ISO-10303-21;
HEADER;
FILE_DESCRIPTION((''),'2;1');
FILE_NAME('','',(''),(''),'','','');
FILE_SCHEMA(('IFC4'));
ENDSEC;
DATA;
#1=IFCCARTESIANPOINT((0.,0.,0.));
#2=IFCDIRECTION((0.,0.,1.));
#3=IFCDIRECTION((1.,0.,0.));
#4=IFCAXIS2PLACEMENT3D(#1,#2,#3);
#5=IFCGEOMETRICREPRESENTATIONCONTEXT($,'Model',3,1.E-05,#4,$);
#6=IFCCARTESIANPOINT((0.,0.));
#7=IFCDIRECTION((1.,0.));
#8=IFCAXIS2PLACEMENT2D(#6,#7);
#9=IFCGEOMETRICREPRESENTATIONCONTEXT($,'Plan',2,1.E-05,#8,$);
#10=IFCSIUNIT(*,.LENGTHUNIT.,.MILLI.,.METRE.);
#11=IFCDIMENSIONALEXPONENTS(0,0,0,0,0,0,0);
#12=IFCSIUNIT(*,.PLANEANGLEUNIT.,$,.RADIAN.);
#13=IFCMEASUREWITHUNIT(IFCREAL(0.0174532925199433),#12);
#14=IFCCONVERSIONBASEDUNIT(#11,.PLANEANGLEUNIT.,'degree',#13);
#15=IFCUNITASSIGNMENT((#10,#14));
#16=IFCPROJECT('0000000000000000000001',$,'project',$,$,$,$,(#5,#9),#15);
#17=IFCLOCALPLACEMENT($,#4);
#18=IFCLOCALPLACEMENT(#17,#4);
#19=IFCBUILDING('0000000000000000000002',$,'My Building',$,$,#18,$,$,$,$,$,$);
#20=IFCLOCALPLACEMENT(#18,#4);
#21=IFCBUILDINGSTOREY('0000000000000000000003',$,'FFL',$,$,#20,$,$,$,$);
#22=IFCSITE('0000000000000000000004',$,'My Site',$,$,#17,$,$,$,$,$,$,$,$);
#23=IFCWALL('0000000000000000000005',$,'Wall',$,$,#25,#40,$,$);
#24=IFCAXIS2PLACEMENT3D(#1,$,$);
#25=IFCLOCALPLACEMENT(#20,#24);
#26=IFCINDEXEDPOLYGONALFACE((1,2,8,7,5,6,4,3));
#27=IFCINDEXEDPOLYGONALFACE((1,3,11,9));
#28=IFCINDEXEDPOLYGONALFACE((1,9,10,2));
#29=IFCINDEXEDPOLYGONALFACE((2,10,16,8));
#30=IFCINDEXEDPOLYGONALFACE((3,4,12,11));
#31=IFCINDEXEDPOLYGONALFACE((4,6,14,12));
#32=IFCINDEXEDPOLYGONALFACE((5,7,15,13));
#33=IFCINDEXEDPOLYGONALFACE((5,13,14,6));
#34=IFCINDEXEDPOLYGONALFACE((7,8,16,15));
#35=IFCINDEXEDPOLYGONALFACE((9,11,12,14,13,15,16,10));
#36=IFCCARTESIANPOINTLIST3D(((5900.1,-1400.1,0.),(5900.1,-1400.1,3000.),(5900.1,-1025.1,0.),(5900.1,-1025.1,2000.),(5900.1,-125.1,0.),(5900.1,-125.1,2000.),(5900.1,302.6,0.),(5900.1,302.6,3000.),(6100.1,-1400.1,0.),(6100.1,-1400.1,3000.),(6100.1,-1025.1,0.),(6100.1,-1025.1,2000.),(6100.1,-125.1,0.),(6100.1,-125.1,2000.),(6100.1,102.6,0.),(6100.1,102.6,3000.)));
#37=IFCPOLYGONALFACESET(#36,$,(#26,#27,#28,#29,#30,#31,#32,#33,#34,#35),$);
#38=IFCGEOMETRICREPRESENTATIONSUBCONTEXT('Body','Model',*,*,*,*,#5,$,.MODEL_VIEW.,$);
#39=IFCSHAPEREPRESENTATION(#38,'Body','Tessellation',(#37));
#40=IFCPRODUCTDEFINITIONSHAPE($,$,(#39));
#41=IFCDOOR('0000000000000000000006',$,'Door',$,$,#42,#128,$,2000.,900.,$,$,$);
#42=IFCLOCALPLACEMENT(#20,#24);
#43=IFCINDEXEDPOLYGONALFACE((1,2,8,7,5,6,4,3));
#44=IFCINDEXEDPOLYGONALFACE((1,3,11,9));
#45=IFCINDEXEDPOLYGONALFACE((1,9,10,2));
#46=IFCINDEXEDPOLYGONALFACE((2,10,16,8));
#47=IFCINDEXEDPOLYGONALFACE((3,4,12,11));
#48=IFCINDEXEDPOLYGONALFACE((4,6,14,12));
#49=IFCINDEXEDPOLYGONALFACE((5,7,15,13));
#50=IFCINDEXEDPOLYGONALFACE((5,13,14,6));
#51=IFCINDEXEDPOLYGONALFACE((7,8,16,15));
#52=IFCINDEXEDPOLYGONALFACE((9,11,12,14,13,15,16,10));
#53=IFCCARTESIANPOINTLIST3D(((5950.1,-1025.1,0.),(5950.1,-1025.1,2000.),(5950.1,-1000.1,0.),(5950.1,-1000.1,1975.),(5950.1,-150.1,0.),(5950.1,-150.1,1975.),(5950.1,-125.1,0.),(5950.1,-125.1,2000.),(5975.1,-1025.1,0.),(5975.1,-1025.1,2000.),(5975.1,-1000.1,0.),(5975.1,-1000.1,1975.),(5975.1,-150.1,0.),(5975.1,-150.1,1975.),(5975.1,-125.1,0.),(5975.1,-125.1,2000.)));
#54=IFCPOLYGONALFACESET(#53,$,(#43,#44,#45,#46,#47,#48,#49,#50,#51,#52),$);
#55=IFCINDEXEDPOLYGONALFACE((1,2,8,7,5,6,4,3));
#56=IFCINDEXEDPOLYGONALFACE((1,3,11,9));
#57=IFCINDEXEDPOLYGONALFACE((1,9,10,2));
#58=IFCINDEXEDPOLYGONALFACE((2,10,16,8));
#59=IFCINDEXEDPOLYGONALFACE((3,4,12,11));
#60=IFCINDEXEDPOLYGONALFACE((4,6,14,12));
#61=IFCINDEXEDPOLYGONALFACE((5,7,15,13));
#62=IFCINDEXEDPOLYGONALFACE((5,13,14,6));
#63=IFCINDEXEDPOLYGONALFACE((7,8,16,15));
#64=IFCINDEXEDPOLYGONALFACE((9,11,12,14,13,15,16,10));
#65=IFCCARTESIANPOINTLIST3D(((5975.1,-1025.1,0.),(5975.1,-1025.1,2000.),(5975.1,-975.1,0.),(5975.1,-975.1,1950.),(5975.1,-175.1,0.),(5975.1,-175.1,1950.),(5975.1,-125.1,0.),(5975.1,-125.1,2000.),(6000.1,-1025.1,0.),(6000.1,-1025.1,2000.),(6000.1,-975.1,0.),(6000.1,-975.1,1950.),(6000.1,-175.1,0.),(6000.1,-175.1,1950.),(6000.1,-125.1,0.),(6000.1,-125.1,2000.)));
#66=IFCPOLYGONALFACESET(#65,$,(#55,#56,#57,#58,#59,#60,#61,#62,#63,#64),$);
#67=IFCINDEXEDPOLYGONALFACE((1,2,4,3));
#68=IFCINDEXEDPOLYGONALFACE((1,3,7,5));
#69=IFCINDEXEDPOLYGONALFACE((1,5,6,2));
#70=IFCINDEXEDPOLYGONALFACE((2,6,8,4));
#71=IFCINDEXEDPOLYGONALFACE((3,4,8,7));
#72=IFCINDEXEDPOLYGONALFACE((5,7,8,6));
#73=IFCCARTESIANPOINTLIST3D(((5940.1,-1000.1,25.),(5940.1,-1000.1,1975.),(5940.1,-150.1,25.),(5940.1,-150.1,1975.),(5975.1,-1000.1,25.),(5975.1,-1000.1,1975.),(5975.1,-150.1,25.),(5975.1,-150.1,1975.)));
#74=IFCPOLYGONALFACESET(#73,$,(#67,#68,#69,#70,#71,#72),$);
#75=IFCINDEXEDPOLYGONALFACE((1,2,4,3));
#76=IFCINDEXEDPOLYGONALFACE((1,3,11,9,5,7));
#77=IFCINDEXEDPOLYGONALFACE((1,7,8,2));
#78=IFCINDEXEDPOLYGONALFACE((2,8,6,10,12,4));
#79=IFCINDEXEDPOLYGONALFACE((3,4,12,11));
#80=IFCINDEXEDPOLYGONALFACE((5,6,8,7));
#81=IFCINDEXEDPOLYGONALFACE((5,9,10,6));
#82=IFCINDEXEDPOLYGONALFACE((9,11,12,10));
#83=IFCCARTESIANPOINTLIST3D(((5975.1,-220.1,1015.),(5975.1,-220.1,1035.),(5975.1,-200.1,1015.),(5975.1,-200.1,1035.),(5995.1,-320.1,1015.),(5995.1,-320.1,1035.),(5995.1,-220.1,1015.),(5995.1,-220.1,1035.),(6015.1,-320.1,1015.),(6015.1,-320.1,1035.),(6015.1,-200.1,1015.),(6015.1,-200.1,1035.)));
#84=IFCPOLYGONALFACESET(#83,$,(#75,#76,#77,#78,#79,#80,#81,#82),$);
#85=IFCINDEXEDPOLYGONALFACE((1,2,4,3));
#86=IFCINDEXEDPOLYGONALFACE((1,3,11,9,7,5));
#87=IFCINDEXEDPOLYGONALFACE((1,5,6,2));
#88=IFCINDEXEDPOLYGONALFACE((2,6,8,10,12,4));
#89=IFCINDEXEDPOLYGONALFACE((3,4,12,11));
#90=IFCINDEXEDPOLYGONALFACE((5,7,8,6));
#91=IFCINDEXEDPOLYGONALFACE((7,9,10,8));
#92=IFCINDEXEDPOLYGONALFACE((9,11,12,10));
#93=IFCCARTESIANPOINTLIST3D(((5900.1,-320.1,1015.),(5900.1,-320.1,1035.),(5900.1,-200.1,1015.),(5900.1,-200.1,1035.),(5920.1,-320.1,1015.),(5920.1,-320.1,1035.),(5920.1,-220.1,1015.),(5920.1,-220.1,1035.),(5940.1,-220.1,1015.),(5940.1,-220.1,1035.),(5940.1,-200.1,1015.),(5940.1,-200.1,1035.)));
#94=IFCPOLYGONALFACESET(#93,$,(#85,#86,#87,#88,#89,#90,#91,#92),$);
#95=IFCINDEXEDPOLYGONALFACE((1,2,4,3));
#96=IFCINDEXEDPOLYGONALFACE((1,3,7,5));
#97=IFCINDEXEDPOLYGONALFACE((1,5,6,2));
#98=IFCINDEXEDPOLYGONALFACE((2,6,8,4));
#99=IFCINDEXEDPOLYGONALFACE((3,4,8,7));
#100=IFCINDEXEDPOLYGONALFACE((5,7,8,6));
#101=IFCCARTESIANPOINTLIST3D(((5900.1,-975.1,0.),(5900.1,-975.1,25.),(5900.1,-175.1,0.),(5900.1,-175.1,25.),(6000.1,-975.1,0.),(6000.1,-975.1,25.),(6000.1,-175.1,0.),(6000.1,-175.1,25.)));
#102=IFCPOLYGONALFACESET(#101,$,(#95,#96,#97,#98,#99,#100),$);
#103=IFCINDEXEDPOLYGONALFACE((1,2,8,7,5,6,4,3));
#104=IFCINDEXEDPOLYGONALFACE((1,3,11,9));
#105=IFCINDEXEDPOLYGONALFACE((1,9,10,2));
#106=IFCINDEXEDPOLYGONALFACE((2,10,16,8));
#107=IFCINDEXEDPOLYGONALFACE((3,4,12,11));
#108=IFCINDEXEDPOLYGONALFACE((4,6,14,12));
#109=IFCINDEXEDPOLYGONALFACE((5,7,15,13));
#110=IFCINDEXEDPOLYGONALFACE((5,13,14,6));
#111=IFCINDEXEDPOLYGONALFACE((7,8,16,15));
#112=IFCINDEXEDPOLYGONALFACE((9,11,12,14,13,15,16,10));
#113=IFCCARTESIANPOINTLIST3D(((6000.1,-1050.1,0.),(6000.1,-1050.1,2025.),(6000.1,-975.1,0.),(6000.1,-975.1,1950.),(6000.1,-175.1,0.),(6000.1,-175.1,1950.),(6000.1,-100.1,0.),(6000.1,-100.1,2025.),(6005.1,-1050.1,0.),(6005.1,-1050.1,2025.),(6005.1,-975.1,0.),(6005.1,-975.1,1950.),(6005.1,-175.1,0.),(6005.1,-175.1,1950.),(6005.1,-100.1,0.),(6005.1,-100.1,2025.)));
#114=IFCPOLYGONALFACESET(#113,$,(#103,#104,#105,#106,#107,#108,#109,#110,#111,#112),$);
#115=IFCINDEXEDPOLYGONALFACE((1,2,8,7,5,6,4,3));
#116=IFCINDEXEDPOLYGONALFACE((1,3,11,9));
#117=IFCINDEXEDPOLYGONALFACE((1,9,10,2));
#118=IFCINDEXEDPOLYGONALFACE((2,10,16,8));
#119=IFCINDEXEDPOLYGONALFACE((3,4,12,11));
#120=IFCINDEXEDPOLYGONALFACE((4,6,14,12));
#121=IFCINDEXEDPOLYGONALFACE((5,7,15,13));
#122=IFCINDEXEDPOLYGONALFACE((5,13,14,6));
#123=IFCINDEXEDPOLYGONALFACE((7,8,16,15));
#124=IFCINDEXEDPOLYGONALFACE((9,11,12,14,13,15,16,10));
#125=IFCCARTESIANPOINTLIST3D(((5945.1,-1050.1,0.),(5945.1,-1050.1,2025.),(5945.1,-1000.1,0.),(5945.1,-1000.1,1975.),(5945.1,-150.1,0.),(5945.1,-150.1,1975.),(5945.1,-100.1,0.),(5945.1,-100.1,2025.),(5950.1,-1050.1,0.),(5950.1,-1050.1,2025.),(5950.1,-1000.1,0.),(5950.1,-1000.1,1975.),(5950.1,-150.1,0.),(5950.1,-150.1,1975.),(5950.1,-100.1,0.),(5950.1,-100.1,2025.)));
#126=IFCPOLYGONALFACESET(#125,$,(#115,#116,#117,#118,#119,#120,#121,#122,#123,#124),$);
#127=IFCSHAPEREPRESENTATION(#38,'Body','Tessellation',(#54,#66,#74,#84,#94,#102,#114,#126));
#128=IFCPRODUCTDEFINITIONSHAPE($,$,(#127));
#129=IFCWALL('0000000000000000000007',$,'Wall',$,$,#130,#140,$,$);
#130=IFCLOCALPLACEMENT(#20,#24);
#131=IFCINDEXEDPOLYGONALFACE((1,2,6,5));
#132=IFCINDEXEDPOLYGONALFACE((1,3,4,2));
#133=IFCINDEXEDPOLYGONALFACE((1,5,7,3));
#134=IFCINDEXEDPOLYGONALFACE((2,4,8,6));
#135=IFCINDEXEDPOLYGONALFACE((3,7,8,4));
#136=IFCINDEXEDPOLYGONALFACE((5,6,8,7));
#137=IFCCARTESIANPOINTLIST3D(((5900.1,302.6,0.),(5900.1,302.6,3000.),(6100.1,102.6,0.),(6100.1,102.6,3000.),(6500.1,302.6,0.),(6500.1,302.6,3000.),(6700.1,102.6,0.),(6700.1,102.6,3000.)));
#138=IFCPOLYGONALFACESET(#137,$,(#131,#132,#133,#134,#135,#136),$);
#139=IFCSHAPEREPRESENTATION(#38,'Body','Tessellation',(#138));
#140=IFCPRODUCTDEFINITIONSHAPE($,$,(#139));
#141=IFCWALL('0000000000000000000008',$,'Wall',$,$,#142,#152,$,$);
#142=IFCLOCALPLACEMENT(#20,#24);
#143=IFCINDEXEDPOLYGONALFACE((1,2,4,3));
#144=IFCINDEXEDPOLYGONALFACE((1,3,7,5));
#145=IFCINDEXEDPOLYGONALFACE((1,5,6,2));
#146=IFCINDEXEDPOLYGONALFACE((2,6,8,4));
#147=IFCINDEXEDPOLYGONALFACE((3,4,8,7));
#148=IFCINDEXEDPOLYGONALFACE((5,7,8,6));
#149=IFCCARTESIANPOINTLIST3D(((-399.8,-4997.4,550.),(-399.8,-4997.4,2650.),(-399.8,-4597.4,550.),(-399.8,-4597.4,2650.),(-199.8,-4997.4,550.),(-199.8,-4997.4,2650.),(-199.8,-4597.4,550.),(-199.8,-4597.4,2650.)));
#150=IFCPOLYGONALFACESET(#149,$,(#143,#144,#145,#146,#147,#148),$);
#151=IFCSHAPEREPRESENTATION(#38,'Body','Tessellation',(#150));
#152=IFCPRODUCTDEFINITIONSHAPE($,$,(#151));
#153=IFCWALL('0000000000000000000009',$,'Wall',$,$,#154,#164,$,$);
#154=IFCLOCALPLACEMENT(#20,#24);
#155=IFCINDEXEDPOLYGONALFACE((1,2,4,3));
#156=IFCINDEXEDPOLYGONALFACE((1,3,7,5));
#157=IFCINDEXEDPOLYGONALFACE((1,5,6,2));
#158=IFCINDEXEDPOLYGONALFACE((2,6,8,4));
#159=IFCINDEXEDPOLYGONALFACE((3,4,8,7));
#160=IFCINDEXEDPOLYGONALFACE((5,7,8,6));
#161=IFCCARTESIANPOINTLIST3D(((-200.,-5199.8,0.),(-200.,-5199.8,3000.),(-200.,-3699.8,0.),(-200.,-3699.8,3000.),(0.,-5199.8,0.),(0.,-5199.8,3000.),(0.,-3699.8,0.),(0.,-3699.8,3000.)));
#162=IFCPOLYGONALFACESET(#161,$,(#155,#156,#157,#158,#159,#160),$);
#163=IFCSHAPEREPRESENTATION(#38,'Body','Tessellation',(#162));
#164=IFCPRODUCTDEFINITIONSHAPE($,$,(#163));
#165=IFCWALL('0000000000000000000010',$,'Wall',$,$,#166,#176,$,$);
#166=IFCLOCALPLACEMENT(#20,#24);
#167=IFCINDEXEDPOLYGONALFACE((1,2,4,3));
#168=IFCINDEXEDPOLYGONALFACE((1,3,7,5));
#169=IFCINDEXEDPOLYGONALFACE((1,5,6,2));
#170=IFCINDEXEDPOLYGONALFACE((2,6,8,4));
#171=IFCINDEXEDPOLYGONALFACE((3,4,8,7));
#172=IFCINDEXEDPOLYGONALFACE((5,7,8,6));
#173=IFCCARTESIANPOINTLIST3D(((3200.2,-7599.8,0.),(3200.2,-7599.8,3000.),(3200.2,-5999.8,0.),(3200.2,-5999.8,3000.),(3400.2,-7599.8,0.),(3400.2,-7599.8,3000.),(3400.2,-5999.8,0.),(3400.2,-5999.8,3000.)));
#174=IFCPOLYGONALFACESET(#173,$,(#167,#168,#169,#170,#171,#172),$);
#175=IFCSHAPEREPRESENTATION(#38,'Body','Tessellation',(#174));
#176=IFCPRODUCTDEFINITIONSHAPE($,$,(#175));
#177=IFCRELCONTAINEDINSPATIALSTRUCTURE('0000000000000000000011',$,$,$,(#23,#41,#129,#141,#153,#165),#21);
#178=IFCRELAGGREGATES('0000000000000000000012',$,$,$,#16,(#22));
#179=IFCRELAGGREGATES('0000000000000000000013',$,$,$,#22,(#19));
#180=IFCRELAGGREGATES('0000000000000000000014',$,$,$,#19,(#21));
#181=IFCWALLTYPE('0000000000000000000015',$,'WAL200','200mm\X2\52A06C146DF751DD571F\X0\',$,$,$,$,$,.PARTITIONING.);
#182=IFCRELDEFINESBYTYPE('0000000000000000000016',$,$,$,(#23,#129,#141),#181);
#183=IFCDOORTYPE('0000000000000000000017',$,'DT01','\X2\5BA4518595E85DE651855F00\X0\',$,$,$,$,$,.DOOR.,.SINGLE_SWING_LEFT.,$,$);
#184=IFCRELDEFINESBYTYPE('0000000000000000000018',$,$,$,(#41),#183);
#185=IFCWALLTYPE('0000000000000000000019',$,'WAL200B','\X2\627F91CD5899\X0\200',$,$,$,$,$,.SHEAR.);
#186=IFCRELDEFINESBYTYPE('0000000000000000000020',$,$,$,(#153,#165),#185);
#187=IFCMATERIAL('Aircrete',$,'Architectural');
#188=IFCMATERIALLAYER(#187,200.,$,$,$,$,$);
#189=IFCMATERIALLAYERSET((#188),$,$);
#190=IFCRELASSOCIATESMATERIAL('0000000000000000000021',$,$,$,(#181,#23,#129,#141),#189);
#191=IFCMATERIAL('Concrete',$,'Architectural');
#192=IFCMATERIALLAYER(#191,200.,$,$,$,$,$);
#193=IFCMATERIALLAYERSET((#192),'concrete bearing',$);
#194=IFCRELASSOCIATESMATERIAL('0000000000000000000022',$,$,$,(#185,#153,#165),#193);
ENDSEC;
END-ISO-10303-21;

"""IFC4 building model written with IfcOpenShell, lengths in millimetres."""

from ifc_helpers import new_model, entity, si_unit, converted_unit, frame, origin_with_axes, origin_2d_with_axis, place, context, subcontext, project, spatial, line, indexed_curve, outline, extrude, shape, source, transform, mapped, material, layer, layer_set, layer_usage, type_object, type_shapes, element, fill, save


model = new_model("IFC4")

# Units and contexts
model_context = context("Model", 3, precision=1e-05, world=origin_with_axes())
plan_context = context("Plan", 2, precision=1e-05, world=origin_2d_with_axis())
body_context_1 = subcontext(model_context, "Body", "Model", "MODEL_VIEW")
body_context_2 = subcontext(plan_context, "Body", "Plan", "PLAN_VIEW")
ifc_project = project(units=[si_unit("LENGTHUNIT", "METRE", prefix="MILLI"), converted_unit("PLANEANGLEUNIT", "degree", entity("IfcReal", 0.0174532925199433), si_unit("PLANEANGLEUNIT", "RADIAN"), dimensions=[0, 0, 0, 0, 0, 0, 0])], contexts=[model_context, plan_context])

# Site, building, storey
site_placement = place(None, origin_with_axes())
site = spatial("IfcSite", under=ifc_project, at=site_placement, Name="My Site")
building_placement = place(site_placement, origin_with_axes())
building = spatial("IfcBuilding", under=site, at=building_placement, Name="My Building")
storey_placement = place(building_placement, origin_with_axes())
storey = spatial("IfcBuildingStorey", under=building, at=storey_placement, Name="FFL")

# Shared definitions
ifc_material_1 = material(Name="Aircrete", Category="Architectural")

# Shared definitions
ifc_layer_1 = layer(ifc_material_1, 200.0)
ifc_layer_set_1 = layer_set([ifc_layer_1])
wall_type_1 = type_object("IfcWallType", Name="WAL200", Description="200mm加气混凝土", PredefinedType="PARTITIONING", material=ifc_layer_set_1)

# Wall, opening, door
ifc_layer_usage_1 = layer_usage(ifc_layer_set_1, "AXIS2", "NEGATIVE", 0.0)
wall_1_placement = place(storey_placement, frame((5900.1, -1400.1, 0.0), z_axis=(0.0, 0.0, 1.0), x_axis=(0.0, 1.0, 0.0)))
wall_1 = element("IfcWall", 1, at=wall_1_placement, inside=storey, type_object=wall_type_1, material=ifc_layer_usage_1, Name="Wall", context=body_context_1, shape_type="SweptSolid", body=[
    extrude(outline(indexed_curve([(0.0, -200.0), (0.0, 0.0), (1702.7, 0.0), (1502.7, -200.0)], segments=[line(1, 2, 3, 4, 1)])), origin_with_axes(), (0.0, 0.0, 1.0), 3000.0),
])
shared_shape_1 = source(origin_with_axes(), body_context_1, "Body", "SweptSolid", [
    extrude(outline(indexed_curve([(0.0, 0.0), (900.0, 0.0), (900.0, 2000.0), (0.0, 2000.0)], segments=[line(1, 2, 3, 4, 1)])), frame((0.0, -600.0, 0.0), z_axis=(0.0, -1.0, 0.0), x_axis=(1.0, 0.0, 0.0)), (0.0, 0.0, -1.0), 1200.0),
])
opening_1_placement = place(wall_1_placement, frame((375.0, -100.0, 0.0), z_axis=(0.0, 0.0, 1.0), x_axis=(1.0, 0.0, 0.0)))
opening_1 = element("IfcOpeningElement", 2, at=opening_1_placement, cuts=wall_1, PredefinedType="OPENING", context=body_context_1, shape_type="MappedRepresentation", body=[
    mapped(shared_shape_1, transform((0.0, 0.0, 0.0), x_axis=(1.0, 0.0, 0.0), y_axis=(0.0, 1.0, 0.0), z_axis=(0.0, 0.0, 1.0), scale=1.0)),
])
door_type = type_object("IfcDoorType", Name="DT01", Description="室内门左内开", OperationType="SINGLE_SWING_LEFT", PredefinedType="DOOR")
shared_shape_2 = source(origin_with_axes(), body_context_1, "Body", "SweptSolid", [
    extrude(outline(indexed_curve([(0.0, 0.0), (0.0, 2000.0), (900.0, 2000.0), (900.0, 0.0), (875.0, 0.0), (875.0, 1975.0), (25.0, 1975.0), (25.0, 0.0)], segments=[line(1, 2, 3, 4, 5, 6, 7, 8, 1)])), frame((0.0, 25.0, 0.0), z_axis=(0.0, -1.0, 0.0), x_axis=(1.0, 0.0, 0.0)), (0.0, 0.0, -1.0), 25.0),
    extrude(outline(indexed_curve([(0.0, 0.0), (0.0, 2000.0), (900.0, 2000.0), (900.0, 0.0), (850.0, 0.0), (850.0, 1950.0), (50.0, 1950.0), (50.0, 0.0)], segments=[line(1, 2, 3, 4, 5, 6, 7, 8, 1)])), frame((0.0, 0.0, 0.0), z_axis=(0.0, -1.0, 0.0), x_axis=(1.0, 0.0, 0.0)), (0.0, 0.0, -1.0), 25.0),
    extrude(outline(indexed_curve([(0.0, 0.0), (850.0, 0.0), (850.0, 35.0), (0.0, 35.0)], segments=[line(1, 2, 3, 4, 1)])), frame((25.0, 25.0, 25.0), z_axis=(0.0, 0.0, 1.0), x_axis=(1.0, 0.0, 0.0)), (0.0, 0.0, 1.0), 1950.0),
    extrude(outline(indexed_curve([(-20.0, 0.0), (-20.0, -20.0), (-120.0, -20.0), (-120.0, -40.0), (0.0, -40.0), (0.0, 0.0), (-20.0, 0.0)])), frame((825.0, 25.0, 1015.0), z_axis=(0.0, 0.0, 1.0), x_axis=(1.0, 0.0, 0.0)), (0.0, 0.0, 1.0), 20.0),
    extrude(outline(indexed_curve([(0.0, 0.0), (0.0, 40.0), (-120.0, 40.0), (-120.0, 20.0), (-20.0, 20.0), (-20.0, 0.0)], segments=[line(1, 2, 3, 4, 5, 6, 1)])), frame((825.0, 60.0, 1015.0), z_axis=(0.0, 0.0, 1.0), x_axis=(1.0, 0.0, 0.0)), (0.0, 0.0, 1.0), 20.0),
    extrude(outline(indexed_curve([(0.0, 0.0), (800.0, 0.0), (800.0, 100.0), (0.0, 100.0)], segments=[line(1, 2, 3, 4, 1)])), frame((50.0, 0.0, 0.0), z_axis=(0.0, 0.0, 1.0), x_axis=(1.0, 0.0, 0.0)), (0.0, 0.0, 1.0), 25.0),
    extrude(outline(indexed_curve([(0.0, 0.0), (0.0, 2025.0), (950.0, 2025.0), (950.0, 0.0), (875.0, 0.0), (875.0, 1950.0), (75.0, 1950.0), (75.0, 0.0)], segments=[line(1, 2, 3, 4, 5, 6, 7, 8, 1)])), frame((-25.0, -5.0, 0.0), z_axis=(0.0, -1.0, 0.0), x_axis=(1.0, 0.0, 0.0)), (0.0, 0.0, -1.0), 5.0),
    extrude(outline(indexed_curve([(0.0, 0.0), (0.0, 2025.0), (950.0, 2025.0), (950.0, 0.0), (900.0, 0.0), (900.0, 1975.0), (50.0, 1975.0), (50.0, 0.0)], segments=[line(1, 2, 3, 4, 5, 6, 7, 8, 1)])), frame((-25.0, 50.0, 0.0), z_axis=(0.0, -1.0, 0.0), x_axis=(1.0, 0.0, 0.0)), (0.0, 0.0, -1.0), 5.0),
])
shared_shape_3 = source(origin_with_axes(), body_context_2, "Body", "Curve2D", [
    entity("IfcIndexedPolyCurve", entity("IfcCartesianPointList2D", [[0.0, 0.0], [0.0, 50.0], [25.0, 50.0], [25.0, 25.0], [50.0, 25.0], [50.0, 0.0]]), [entity("IfcLineIndex", [1, 2, 3, 4, 5, 6, 1])]),
    entity("IfcIndexedPolyCurve", entity("IfcCartesianPointList2D", [[900.0, 0.0], [900.0, 50.0], [875.0, 50.0], [875.0, 25.0], [850.0, 25.0], [850.0, 0.0]]), [entity("IfcLineIndex", [1, 2, 3, 4, 5, 6, 1])]),
    entity("IfcTrimmedCurve", entity("IfcEllipse", entity("IfcAxis2Placement2D", entity("IfcCartesianPoint", [60.0, 50.0]), entity("IfcDirection", [1.0, 0.0])), 815.0, 850.0), [entity("IfcCartesianPoint", [875.0, 50.0])], [entity("IfcCartesianPoint", [60.0, 900.0])], True, "CARTESIAN"),
    entity("IfcIndexedPolyCurve", entity("IfcCartesianPointList2D", [[25.0, 50.0], [60.0, 50.0], [60.0, 900.0], [25.0, 900.0]]), [entity("IfcLineIndex", [1, 2, 3, 4, 1])]),
])
type_shapes(door_type, [shared_shape_2, shared_shape_3])
door_placement = place(opening_1_placement, frame((0.0, 0.0, 0.0), z_axis=(0.0, 0.0, 1.0), x_axis=(1.0, 0.0, 0.0)))
door = element("IfcDoor", 3, at=door_placement, inside=storey, type_object=door_type, Name="Door", OverallHeight=2000.0, OverallWidth=900.0, shapes=[
    shape(body_context_1, "Body", "MappedRepresentation", [mapped(shared_shape_2, transform((0.0, 0.0, 0.0), x_axis=(1.0, 0.0, 0.0), y_axis=(0.0, 1.0, 0.0), z_axis=(0.0, 0.0, 1.0), scale=1.0))]),
    shape(body_context_2, "Body", "MappedRepresentation", [mapped(shared_shape_3, transform((0.0, 0.0, 0.0), x_axis=(1.0, 0.0, 0.0), y_axis=(0.0, 1.0, 0.0), z_axis=(0.0, 0.0, 1.0), scale=1.0))]),
])
fill(opening_1, door)

# Walls
ifc_layer_usage_2 = layer_usage(ifc_layer_set_1, "AXIS2", "NEGATIVE", 0.0)
wall_2_placement = place(storey_placement, frame((5900.1, 302.6, 0.0), z_axis=(0.0, 0.0, 1.0), x_axis=(1.0, 0.0, 0.0)))
element("IfcWall", 4, at=wall_2_placement, inside=storey, type_object=wall_type_1, material=ifc_layer_usage_2, Name="Wall", context=body_context_1, shape_type="SweptSolid", body=[
    extrude(outline(indexed_curve([(200.0, -200.0), (0.0, 0.0), (600.0, 0.0), (800.0, -200.0)], segments=[line(1, 2, 3, 4, 1)])), origin_with_axes(), (0.0, 0.0, 1.0), 3000.0),
])
ifc_layer_usage_3 = layer_usage(ifc_layer_set_1, "AXIS2", "NEGATIVE", 0.0)
wall_3_placement = place(storey_placement, frame((-399.8, -4997.4, 550.0), z_axis=(0.0, 0.0, 1.0), x_axis=(0.0, 1.0, 0.0)))
element("IfcWall", 5, at=wall_3_placement, inside=storey, type_object=wall_type_1, material=ifc_layer_usage_3, Name="Wall", context=body_context_1, shape_type="SweptSolid", body=[
    extrude(outline(indexed_curve([(0.0, -200.0), (0.0, 0.0), (400.0, 0.0), (400.0, -200.0)], segments=[line(1, 2, 3, 4, 1)])), origin_with_axes(), (0.0, 0.0, 1.0), 2100.0),
])

# Walls
ifc_material_2 = material(Name="Concrete", Category="Architectural")
ifc_layer_2 = layer(ifc_material_2, 200.0)
ifc_layer_set_2 = layer_set([ifc_layer_2], Name="concrete bearing")
ifc_layer_usage_4 = layer_usage(ifc_layer_set_2, "AXIS2", "NEGATIVE", 0.0)
wall_type_2 = type_object("IfcWallType", Name="WAL200B", Description="承重墙200", PredefinedType="SHEAR", material=ifc_layer_set_2)
wall_4_placement = place(storey_placement, frame((-200.0, -5199.8, 0.0), z_axis=(0.0, 0.0, 1.0), x_axis=(-0.000008, 1.0, 0.0)))
element("IfcWall", 6, at=wall_4_placement, inside=storey, type_object=wall_type_2, material=ifc_layer_usage_4, Name="Wall", context=body_context_1, shape_type="SweptSolid", body=[
    extrude(outline(indexed_curve([(0.0, -200.0), (0.0, 0.0), (1500.0, 0.0), (1500.0, -200.0)], segments=[line(1, 2, 3, 4, 1)])), origin_with_axes(), (0.0, 0.0, 1.0), 3000.0),
])
ifc_layer_usage_5 = layer_usage(ifc_layer_set_2, "AXIS2", "NEGATIVE", 0.0)
wall_5_placement = place(storey_placement, frame((3400.2, -5999.8, 0.0), z_axis=(0.0, 0.0, 1.0), x_axis=(0.0, -1.0, 0.0)))
element("IfcWall", 7, at=wall_5_placement, inside=storey, type_object=wall_type_2, material=ifc_layer_usage_5, Name="Wall", context=body_context_1, shape_type="SweptSolid", body=[
    extrude(outline(indexed_curve([(0.0, -200.0), (0.0, 0.0), (1600.0, 0.0), (1600.0, -200.0)], segments=[line(1, 2, 3, 4, 1)])), origin_with_axes(), (0.0, 0.0, 1.0), 3000.0),
])

save(model, "model.ifc")
